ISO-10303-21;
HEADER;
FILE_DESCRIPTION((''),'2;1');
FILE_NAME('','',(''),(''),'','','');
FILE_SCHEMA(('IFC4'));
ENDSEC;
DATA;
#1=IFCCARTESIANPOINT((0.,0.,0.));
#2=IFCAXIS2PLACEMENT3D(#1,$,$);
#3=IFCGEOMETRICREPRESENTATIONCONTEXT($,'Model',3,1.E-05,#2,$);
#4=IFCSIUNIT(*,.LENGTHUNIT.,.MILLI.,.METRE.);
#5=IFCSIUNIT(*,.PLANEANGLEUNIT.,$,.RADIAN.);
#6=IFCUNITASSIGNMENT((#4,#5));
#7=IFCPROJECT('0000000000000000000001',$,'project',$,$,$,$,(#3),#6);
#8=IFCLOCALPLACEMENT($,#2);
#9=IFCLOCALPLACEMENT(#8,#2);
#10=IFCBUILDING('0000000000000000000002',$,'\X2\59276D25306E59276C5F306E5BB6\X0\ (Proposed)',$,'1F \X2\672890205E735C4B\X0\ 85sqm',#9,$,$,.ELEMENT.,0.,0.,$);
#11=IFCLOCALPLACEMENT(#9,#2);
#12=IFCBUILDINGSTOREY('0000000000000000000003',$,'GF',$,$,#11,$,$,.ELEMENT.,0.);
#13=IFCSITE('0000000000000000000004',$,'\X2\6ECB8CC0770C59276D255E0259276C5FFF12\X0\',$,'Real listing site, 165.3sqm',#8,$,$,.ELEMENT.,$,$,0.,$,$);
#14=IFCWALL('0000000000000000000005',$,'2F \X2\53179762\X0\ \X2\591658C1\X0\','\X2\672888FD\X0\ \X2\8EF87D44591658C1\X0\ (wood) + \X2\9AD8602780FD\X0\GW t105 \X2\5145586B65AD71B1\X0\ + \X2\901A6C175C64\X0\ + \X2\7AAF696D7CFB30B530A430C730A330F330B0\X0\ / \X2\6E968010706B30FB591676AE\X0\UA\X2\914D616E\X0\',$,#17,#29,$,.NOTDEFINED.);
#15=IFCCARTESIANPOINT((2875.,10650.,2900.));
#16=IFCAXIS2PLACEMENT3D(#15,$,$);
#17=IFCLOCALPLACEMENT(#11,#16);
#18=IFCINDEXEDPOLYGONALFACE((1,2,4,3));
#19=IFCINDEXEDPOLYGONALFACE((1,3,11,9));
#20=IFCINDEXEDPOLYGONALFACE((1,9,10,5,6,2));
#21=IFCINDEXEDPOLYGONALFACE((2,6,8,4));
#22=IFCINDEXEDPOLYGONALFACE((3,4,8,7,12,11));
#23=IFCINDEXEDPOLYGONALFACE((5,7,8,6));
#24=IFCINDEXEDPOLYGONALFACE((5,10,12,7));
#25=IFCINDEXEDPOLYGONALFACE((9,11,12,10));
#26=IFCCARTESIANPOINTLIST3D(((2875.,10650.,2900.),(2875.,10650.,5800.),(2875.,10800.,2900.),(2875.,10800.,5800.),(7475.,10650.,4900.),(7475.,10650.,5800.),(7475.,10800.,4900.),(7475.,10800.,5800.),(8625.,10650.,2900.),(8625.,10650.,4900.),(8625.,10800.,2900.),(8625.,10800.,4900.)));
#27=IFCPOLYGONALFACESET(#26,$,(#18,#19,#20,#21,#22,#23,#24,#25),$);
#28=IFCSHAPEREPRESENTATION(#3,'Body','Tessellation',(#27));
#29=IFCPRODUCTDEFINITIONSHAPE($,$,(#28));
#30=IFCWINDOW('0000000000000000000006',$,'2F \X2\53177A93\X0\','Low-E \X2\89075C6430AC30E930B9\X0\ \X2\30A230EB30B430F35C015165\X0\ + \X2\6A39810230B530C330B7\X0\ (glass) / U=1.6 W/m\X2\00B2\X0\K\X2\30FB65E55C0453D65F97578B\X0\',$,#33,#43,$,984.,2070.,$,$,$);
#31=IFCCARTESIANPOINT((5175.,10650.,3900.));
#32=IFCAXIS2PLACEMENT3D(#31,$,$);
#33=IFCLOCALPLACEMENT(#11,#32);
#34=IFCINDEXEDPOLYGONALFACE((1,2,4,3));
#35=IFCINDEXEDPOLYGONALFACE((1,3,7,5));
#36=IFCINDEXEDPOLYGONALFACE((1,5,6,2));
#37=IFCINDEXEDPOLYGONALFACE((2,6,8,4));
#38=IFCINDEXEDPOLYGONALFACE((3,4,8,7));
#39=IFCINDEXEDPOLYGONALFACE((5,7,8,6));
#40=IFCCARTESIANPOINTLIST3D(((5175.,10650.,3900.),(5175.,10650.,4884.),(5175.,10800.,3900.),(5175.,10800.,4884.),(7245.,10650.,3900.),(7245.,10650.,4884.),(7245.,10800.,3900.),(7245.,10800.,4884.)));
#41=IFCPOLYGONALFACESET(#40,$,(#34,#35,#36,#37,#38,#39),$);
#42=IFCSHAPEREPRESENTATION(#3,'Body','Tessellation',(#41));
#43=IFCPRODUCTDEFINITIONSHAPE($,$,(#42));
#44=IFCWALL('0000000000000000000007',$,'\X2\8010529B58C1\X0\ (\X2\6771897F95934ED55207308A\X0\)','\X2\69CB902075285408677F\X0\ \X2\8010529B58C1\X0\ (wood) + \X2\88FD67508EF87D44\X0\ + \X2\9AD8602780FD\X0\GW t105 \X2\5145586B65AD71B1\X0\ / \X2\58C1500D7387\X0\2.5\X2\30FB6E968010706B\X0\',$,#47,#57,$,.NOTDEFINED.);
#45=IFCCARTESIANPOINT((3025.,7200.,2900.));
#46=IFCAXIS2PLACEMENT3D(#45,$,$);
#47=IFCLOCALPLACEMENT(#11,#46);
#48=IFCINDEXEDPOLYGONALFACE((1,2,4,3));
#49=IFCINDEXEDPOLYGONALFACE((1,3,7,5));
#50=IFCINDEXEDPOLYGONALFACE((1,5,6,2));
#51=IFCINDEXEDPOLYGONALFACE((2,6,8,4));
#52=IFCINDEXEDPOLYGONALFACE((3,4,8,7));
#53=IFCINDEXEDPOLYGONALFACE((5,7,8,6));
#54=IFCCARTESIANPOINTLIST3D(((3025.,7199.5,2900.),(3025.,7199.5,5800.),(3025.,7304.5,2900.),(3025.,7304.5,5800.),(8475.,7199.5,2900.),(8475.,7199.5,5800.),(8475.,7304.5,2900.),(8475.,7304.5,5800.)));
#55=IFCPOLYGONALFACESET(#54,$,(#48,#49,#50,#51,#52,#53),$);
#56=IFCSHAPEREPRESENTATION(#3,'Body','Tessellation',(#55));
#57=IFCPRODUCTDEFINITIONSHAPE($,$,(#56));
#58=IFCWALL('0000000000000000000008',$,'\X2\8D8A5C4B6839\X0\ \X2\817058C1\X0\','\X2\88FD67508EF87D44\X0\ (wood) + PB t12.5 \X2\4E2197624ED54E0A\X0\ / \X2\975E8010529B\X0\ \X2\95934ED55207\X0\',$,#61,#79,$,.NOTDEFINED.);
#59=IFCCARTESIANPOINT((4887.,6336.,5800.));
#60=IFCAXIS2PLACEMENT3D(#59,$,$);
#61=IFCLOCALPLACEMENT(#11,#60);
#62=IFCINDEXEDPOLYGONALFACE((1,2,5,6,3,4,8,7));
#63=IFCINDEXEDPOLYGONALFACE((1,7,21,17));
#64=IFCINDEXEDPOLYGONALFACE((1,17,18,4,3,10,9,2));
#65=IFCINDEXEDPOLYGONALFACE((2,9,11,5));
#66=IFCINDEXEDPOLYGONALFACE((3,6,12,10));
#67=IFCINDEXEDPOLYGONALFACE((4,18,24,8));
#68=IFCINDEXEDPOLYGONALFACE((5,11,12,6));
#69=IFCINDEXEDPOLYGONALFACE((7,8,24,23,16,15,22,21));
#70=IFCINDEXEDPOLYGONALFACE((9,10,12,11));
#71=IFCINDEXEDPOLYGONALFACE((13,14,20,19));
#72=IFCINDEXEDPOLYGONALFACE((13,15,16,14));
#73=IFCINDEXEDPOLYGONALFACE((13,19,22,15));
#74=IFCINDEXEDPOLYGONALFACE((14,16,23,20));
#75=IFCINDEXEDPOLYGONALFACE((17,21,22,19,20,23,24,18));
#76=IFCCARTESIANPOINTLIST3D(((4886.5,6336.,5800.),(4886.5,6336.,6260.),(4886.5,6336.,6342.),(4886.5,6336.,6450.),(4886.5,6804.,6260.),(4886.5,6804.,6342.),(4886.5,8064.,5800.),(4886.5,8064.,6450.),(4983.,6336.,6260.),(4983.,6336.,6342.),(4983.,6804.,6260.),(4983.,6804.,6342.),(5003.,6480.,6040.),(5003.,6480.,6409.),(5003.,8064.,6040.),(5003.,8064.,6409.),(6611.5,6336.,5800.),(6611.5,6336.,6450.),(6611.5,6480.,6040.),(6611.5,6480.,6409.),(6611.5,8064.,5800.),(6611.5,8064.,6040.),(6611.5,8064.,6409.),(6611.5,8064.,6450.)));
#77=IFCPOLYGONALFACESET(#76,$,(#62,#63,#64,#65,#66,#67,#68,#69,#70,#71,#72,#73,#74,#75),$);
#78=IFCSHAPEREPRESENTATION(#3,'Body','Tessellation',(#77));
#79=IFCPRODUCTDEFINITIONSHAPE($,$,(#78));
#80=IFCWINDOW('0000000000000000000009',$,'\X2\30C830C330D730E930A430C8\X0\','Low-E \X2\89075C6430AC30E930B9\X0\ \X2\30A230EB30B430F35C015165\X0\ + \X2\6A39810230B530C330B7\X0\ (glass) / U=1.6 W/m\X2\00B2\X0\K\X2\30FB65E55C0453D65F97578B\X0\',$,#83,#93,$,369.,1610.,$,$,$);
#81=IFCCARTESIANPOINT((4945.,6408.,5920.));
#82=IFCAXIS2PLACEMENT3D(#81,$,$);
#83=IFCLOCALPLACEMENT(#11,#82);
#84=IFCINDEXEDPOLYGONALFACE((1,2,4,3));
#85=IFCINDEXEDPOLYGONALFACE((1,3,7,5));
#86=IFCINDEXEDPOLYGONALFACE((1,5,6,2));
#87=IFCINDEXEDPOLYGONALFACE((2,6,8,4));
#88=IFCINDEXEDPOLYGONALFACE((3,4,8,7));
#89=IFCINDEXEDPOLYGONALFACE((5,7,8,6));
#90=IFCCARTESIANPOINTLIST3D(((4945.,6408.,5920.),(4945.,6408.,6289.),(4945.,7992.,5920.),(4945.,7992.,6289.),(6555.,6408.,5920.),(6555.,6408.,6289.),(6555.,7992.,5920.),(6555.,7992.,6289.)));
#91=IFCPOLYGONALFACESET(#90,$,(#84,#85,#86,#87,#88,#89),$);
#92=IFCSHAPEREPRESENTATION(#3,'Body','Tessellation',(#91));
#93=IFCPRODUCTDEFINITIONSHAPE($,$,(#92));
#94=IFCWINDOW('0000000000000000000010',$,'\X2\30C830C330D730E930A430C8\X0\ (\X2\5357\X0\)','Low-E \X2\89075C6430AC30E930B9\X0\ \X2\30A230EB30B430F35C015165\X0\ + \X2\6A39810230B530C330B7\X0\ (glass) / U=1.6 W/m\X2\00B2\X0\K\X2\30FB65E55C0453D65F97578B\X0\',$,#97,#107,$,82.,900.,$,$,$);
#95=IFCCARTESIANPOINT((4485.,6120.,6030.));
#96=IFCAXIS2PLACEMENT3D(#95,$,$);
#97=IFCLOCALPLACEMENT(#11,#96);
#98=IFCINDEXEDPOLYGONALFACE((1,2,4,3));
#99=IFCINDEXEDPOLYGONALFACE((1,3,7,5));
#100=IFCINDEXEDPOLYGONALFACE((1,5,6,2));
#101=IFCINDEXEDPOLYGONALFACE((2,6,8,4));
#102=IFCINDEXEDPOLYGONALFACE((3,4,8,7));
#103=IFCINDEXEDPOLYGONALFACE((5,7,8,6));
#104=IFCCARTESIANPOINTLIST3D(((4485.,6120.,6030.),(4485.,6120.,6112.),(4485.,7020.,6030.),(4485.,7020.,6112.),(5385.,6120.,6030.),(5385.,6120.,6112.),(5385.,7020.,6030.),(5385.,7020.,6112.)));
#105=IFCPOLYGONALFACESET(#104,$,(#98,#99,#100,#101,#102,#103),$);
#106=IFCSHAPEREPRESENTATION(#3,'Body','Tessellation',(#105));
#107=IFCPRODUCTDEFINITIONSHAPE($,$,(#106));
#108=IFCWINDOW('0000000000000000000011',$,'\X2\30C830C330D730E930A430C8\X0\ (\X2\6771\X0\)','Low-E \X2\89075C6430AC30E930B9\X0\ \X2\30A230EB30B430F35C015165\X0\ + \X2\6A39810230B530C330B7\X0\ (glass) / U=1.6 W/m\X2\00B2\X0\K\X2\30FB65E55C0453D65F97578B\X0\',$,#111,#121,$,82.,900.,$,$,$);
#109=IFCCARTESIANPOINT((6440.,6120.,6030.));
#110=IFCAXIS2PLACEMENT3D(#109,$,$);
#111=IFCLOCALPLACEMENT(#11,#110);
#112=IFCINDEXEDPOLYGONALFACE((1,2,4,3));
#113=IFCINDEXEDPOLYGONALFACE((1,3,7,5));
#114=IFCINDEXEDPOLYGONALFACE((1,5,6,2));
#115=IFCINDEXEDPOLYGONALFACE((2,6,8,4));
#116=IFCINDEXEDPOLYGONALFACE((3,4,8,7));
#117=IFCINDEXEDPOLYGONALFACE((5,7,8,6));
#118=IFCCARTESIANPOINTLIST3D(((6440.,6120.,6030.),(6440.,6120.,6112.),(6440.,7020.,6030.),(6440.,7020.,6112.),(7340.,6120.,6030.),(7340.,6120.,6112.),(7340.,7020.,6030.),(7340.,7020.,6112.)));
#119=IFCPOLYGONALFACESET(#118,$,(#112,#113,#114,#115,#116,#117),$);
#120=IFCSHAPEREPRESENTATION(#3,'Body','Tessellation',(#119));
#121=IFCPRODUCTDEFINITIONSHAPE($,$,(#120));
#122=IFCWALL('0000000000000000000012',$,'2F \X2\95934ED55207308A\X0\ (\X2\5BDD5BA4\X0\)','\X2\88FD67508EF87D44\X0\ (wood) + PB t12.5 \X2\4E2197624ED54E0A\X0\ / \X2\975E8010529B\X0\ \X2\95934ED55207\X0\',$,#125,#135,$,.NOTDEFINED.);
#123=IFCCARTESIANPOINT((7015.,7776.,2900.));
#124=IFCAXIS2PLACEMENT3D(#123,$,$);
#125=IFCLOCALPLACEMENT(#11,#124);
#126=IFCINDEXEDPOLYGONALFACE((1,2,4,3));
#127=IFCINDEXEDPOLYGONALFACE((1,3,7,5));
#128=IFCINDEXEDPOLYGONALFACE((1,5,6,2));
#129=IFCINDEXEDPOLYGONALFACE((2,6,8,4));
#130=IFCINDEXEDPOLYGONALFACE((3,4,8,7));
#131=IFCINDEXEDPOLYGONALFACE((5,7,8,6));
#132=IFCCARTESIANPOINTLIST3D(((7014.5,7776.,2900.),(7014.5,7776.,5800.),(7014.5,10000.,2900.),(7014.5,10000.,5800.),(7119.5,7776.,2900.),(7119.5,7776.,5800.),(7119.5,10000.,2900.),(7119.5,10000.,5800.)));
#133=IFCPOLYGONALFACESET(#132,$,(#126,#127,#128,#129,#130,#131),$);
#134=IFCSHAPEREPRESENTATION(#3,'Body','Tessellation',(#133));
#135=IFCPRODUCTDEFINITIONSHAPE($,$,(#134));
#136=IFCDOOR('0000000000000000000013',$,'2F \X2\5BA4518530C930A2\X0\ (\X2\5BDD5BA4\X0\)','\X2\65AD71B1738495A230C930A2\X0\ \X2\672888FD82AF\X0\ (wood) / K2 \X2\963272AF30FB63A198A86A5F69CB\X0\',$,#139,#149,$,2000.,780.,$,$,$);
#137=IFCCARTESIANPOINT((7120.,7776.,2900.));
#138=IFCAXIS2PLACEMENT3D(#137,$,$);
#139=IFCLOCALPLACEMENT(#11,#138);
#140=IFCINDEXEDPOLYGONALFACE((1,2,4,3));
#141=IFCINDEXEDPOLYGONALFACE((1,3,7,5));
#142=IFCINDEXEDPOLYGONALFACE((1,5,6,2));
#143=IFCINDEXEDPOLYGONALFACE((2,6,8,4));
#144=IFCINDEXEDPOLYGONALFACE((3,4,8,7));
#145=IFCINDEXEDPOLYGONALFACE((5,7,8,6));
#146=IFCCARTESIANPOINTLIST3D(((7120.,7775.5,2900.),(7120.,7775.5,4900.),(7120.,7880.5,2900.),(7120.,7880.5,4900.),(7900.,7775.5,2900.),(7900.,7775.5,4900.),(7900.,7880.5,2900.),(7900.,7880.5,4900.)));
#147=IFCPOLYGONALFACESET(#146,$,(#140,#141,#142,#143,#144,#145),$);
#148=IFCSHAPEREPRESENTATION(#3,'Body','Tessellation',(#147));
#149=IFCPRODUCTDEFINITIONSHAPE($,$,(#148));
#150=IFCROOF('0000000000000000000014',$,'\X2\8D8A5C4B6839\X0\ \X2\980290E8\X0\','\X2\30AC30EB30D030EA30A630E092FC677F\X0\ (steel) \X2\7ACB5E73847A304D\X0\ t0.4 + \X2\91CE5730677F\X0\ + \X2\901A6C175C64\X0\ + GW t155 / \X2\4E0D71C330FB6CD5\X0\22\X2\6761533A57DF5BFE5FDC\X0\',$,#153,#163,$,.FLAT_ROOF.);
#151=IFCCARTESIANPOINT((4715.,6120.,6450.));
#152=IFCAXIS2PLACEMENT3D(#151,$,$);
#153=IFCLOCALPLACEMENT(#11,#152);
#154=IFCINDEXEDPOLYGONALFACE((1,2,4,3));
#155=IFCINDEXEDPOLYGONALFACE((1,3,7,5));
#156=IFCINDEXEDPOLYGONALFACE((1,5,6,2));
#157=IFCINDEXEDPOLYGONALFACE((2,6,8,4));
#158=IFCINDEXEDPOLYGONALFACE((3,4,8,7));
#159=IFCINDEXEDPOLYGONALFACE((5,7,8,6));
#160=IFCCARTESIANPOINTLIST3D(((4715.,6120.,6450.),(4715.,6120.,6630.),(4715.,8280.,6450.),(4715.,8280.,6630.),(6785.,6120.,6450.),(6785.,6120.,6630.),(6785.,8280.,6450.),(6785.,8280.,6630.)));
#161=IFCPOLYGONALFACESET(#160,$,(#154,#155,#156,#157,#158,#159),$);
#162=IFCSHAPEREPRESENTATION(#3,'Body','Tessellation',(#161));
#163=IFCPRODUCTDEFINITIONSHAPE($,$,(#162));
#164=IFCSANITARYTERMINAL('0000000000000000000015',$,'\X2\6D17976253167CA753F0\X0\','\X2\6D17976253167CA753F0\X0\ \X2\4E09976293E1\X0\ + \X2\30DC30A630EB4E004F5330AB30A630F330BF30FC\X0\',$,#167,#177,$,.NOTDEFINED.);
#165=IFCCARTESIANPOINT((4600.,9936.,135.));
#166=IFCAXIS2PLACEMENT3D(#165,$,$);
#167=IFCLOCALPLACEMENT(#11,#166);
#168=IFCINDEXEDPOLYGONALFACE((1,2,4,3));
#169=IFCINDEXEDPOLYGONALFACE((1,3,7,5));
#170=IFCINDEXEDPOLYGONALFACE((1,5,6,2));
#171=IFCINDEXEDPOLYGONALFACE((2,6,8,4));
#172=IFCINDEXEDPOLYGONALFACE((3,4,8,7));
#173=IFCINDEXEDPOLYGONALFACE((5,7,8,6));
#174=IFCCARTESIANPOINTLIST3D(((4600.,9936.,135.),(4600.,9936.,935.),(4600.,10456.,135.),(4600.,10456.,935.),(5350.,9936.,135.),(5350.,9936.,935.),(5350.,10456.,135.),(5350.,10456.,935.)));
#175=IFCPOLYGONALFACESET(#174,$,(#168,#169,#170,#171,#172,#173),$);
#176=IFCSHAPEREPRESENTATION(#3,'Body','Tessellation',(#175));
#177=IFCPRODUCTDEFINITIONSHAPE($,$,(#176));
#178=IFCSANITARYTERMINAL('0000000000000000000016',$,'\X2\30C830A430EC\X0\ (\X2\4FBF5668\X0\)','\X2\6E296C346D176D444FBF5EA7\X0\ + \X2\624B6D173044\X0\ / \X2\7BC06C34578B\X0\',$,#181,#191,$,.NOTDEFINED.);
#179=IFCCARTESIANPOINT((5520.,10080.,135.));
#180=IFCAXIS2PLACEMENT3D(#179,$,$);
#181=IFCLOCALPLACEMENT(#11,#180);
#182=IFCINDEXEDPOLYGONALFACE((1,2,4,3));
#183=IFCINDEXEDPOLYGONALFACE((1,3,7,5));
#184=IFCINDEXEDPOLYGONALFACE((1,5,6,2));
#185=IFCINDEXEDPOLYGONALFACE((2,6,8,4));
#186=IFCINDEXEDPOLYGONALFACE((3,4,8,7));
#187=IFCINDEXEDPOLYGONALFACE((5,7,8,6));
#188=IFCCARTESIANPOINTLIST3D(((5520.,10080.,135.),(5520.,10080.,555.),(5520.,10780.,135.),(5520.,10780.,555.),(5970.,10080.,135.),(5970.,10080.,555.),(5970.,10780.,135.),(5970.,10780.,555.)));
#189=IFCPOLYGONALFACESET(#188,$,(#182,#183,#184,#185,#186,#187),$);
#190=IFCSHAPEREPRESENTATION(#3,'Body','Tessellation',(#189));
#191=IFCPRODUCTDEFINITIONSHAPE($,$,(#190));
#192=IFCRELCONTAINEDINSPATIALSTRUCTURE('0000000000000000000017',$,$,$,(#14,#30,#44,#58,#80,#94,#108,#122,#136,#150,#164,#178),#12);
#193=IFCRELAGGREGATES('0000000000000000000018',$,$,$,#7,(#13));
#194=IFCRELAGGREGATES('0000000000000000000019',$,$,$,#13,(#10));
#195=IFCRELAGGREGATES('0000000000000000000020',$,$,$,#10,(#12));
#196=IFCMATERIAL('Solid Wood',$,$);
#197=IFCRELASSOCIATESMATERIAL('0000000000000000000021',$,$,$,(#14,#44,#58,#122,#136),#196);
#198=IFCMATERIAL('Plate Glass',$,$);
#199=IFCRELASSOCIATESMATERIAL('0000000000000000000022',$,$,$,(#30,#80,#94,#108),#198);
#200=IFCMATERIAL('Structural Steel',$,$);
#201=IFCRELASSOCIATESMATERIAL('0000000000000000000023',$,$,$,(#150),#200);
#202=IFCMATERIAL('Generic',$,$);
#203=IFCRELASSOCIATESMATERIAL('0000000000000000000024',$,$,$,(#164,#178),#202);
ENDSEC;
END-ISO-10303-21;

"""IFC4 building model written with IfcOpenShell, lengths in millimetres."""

from ifc_helpers import new_model, si_unit, frame, frame_2d, origin, place, context, project, spatial, rectangle, extrude, material, element, fill, save


model = new_model("IFC4")

# Units and contexts
model_context = context("Model", 3, precision=1e-05, world=origin())
ifc_project = project(units=[si_unit("LENGTHUNIT", "METRE", prefix="MILLI"), si_unit("PLANEANGLEUNIT", "RADIAN")], contexts=[model_context])

# Site, building, storey
site_placement = place(None, origin())
site = spatial("IfcSite", under=ifc_project, at=site_placement, Name="滋賀県大津市大江２", ObjectType="Real listing site, 165.3sqm", CompositionType="ELEMENT", RefElevation=0.0)
building_placement = place(site_placement, origin())
building = spatial("IfcBuilding", under=site, at=building_placement, Name="大津の大江の家 (Proposed)", ObjectType="1F 木造平屋 85sqm", CompositionType="ELEMENT", ElevationOfRefHeight=0.0, ElevationOfTerrain=0.0)
storey_placement = place(building_placement, origin())
storey = spatial("IfcBuildingStorey", under=building, at=storey_placement, Name="GF", CompositionType="ELEMENT", Elevation=0.0)

# Wall, opening, window
ifc_material_1 = material(Name="Solid Wood")
wall_1_placement = place(storey_placement, frame((2875.0, 10650.0, 2900.0)))
wall_1 = element("IfcWall", 1, at=wall_1_placement, inside=storey, material=ifc_material_1, Name="2F 北面 外壁", Description="木製 軸組外壁 (wood) + 高性能GW t105 充填断熱 + 通気層 + 窯業系サイディング / 準耐火・外皮UA配慮", PredefinedType="NOTDEFINED", context=model_context, shape_type="SweptSolid", body=[
    extrude(rectangle(XDim=5750.0, YDim=150.0, at=frame_2d((2875.0, 75.0))), frame((2875.0, 10650.0, 2900.0)), (0.0, 0.0, 1.0), 2900.0),
])
opening_1_placement = place(storey_placement, frame((5175.0, 10650.0, 3900.0)))
opening_1 = element("IfcOpeningElement", 2, at=opening_1_placement, cuts=wall_1, PredefinedType="NOTDEFINED", context=model_context, shape_type="SweptSolid", body=[
    extrude(rectangle(XDim=2070.0, YDim=150.0, at=frame_2d((1035.0, 75.0))), frame((5175.0, 10650.0, 3900.0)), (0.0, 0.0, 1.0), 984.0),
])
ifc_material_2 = material(Name="Plate Glass")
window_1_placement = place(storey_placement, frame((5175.0, 10650.0, 3900.0)))
window_1 = element("IfcWindow", 3, at=window_1_placement, inside=storey, material=ifc_material_2, Name="2F 北窓", Description="Low-E 複層ガラス アルゴン封入 + 樹脂サッシ (glass) / U=1.6 W/m²K・日射取得型", OverallHeight=984.0, OverallWidth=2070.0, context=model_context, shape_type="SweptSolid", body=[
    extrude(rectangle(XDim=2070.0, YDim=150.0, at=frame_2d((1035.0, 75.0))), frame((5175.0, 10650.0, 3900.0)), (0.0, 0.0, 1.0), 984.0),
])
fill(opening_1, window_1)

# Wall
wall_2_placement = place(storey_placement, frame((3025.0, 7200.0, 2900.0)))
element("IfcWall", 4, at=wall_2_placement, inside=storey, material=ifc_material_1, Name="耐力壁 (東西間仕切り)", Description="構造用合板 耐力壁 (wood) + 製材軸組 + 高性能GW t105 充填断熱 / 壁倍率2.5・準耐火", PredefinedType="NOTDEFINED", context=model_context, shape_type="SweptSolid", body=[
    extrude(rectangle(XDim=5450.0, YDim=105.0, at=frame_2d((2725.0, 52.0))), frame((3025.0, 7200.0, 2900.0)), (0.0, 0.0, 1.0), 2900.0),
])

# Wall, openings, windows
wall_3_placement = place(storey_placement, frame((4887.0, 6336.0, 5800.0)))
wall_3 = element("IfcWall", 5, at=wall_3_placement, inside=storey, material=ifc_material_1, Name="越屋根 腰壁", Description="製材軸組 (wood) + PB t12.5 両面仕上 / 非耐力 間仕切", PredefinedType="NOTDEFINED", context=model_context, shape_type="SweptSolid", body=[
    extrude(rectangle(XDim=1725.0, YDim=1728.0, at=frame_2d((862.0, 864.0))), frame((4887.0, 6336.0, 5800.0)), (0.0, 0.0, 1.0), 650.0),
])
opening_2_placement = place(storey_placement, frame((4945.0, 6408.0, 5920.0)))
opening_2 = element("IfcOpeningElement", 6, at=opening_2_placement, cuts=wall_3, PredefinedType="NOTDEFINED", context=model_context, shape_type="SweptSolid", body=[
    extrude(rectangle(XDim=1610.0, YDim=1584.0, at=frame_2d((805.0, 792.0))), frame((4945.0, 6408.0, 5920.0)), (0.0, 0.0, 1.0), 369.0),
])
opening_3_placement = place(storey_placement, frame((4485.0, 6120.0, 6030.0)))
opening_3 = element("IfcOpeningElement", 7, at=opening_3_placement, cuts=wall_3, PredefinedType="NOTDEFINED", context=model_context, shape_type="SweptSolid", body=[
    extrude(rectangle(XDim=900.0, YDim=900.0, at=frame_2d((450.0, 450.0))), frame((4485.0, 6120.0, 6030.0)), (0.0, 0.0, 1.0), 82.0),
])
opening_4_placement = place(storey_placement, frame((6440.0, 6120.0, 6030.0)))
opening_4 = element("IfcOpeningElement", 8, at=opening_4_placement, cuts=wall_3, PredefinedType="NOTDEFINED", context=model_context, shape_type="SweptSolid", body=[
    extrude(rectangle(XDim=900.0, YDim=900.0, at=frame_2d((450.0, 450.0))), frame((6440.0, 6120.0, 6030.0)), (0.0, 0.0, 1.0), 82.0),
])
window_2_placement = place(storey_placement, frame((4945.0, 6408.0, 5920.0)))
window_2 = element("IfcWindow", 9, at=window_2_placement, inside=storey, material=ifc_material_2, Name="トップライト", Description="Low-E 複層ガラス アルゴン封入 + 樹脂サッシ (glass) / U=1.6 W/m²K・日射取得型", OverallHeight=369.0, OverallWidth=1610.0, context=model_context, shape_type="SweptSolid", body=[
    extrude(rectangle(XDim=1610.0, YDim=1584.0, at=frame_2d((805.0, 792.0))), frame((4945.0, 6408.0, 5920.0)), (0.0, 0.0, 1.0), 369.0),
])
fill(opening_2, window_2)
window_3_placement = place(storey_placement, frame((4485.0, 6120.0, 6030.0)))
window_3 = element("IfcWindow", 10, at=window_3_placement, inside=storey, material=ifc_material_2, Name="トップライト (南)", Description="Low-E 複層ガラス アルゴン封入 + 樹脂サッシ (glass) / U=1.6 W/m²K・日射取得型", OverallHeight=82.0, OverallWidth=900.0, context=model_context, shape_type="SweptSolid", body=[
    extrude(rectangle(XDim=900.0, YDim=900.0, at=frame_2d((450.0, 450.0))), frame((4485.0, 6120.0, 6030.0)), (0.0, 0.0, 1.0), 82.0),
])
fill(opening_3, window_3)
window_4_placement = place(storey_placement, frame((6440.0, 6120.0, 6030.0)))
window_4 = element("IfcWindow", 11, at=window_4_placement, inside=storey, material=ifc_material_2, Name="トップライト (東)", Description="Low-E 複層ガラス アルゴン封入 + 樹脂サッシ (glass) / U=1.6 W/m²K・日射取得型", OverallHeight=82.0, OverallWidth=900.0, context=model_context, shape_type="SweptSolid", body=[
    extrude(rectangle(XDim=900.0, YDim=900.0, at=frame_2d((450.0, 450.0))), frame((6440.0, 6120.0, 6030.0)), (0.0, 0.0, 1.0), 82.0),
])
fill(opening_4, window_4)

# Wall
wall_4_placement = place(storey_placement, frame((7015.0, 7776.0, 2900.0)))
element("IfcWall", 12, at=wall_4_placement, inside=storey, material=ifc_material_1, Name="2F 間仕切り (寝室)", Description="製材軸組 (wood) + PB t12.5 両面仕上 / 非耐力 間仕切", PredefinedType="NOTDEFINED", context=model_context, shape_type="SweptSolid", body=[
    extrude(rectangle(XDim=105.0, YDim=2224.0, at=frame_2d((52.0, 1112.0))), frame((7015.0, 7776.0, 2900.0)), (0.0, 0.0, 1.0), 2900.0),
])

# Door
door_placement = place(storey_placement, frame((7120.0, 7776.0, 2900.0)))
element("IfcDoor", 13, at=door_placement, inside=storey, material=ifc_material_1, Name="2F 室内ドア (寝室)", Description="断熱玄関ドア 木製芯 (wood) / K2 防犯・採風機構", OverallHeight=2000.0, OverallWidth=780.0, context=model_context, shape_type="SweptSolid", body=[
    extrude(rectangle(XDim=780.0, YDim=105.0, at=frame_2d((390.0, 52.0))), frame((7120.0, 7776.0, 2900.0)), (0.0, 0.0, 1.0), 2000.0),
])

# Roof
ifc_material_3 = material(Name="Structural Steel")
roof_placement = place(storey_placement, frame((4715.0, 6120.0, 6450.0)))
element("IfcRoof", 14, at=roof_placement, inside=storey, material=ifc_material_3, Name="越屋根 頂部", Description="ガルバリウム鋼板 (steel) 立平葺き t0.4 + 野地板 + 通気層 + GW t155 / 不燃・法22条区域対応", PredefinedType="FLAT_ROOF", context=model_context, shape_type="SweptSolid", body=[
    extrude(rectangle(XDim=2070.0, YDim=2160.0, at=frame_2d((1035.0, 1080.0))), frame((4715.0, 6120.0, 6450.0)), (0.0, 0.0, 1.0), 180.0),
])

# Sanitary terminals
ifc_material_4 = material(Name="Generic")
sanitary_terminal_1_placement = place(storey_placement, frame((4600.0, 9936.0, 135.0)))
element("IfcSanitaryTerminal", 15, at=sanitary_terminal_1_placement, inside=storey, material=ifc_material_4, Name="洗面化粧台", Description="洗面化粧台 三面鏡 + ボウル一体カウンター", PredefinedType="NOTDEFINED", context=model_context, shape_type="SweptSolid", body=[
    extrude(rectangle(XDim=750.0, YDim=520.0, at=frame_2d((375.0, 260.0))), frame((4600.0, 9936.0, 135.0)), (0.0, 0.0, 1.0), 800.0),
])
sanitary_terminal_2_placement = place(storey_placement, frame((5520.0, 10080.0, 135.0)))
element("IfcSanitaryTerminal", 16, at=sanitary_terminal_2_placement, inside=storey, material=ifc_material_4, Name="トイレ (便器)", Description="温水洗浄便座 + 手洗い / 節水型", PredefinedType="NOTDEFINED", context=model_context, shape_type="SweptSolid", body=[
    extrude(rectangle(XDim=450.0, YDim=700.0, at=frame_2d((225.0, 350.0))), frame((5520.0, 10080.0, 135.0)), (0.0, 0.0, 1.0), 420.0),
])

save(model, "model.ifc")
